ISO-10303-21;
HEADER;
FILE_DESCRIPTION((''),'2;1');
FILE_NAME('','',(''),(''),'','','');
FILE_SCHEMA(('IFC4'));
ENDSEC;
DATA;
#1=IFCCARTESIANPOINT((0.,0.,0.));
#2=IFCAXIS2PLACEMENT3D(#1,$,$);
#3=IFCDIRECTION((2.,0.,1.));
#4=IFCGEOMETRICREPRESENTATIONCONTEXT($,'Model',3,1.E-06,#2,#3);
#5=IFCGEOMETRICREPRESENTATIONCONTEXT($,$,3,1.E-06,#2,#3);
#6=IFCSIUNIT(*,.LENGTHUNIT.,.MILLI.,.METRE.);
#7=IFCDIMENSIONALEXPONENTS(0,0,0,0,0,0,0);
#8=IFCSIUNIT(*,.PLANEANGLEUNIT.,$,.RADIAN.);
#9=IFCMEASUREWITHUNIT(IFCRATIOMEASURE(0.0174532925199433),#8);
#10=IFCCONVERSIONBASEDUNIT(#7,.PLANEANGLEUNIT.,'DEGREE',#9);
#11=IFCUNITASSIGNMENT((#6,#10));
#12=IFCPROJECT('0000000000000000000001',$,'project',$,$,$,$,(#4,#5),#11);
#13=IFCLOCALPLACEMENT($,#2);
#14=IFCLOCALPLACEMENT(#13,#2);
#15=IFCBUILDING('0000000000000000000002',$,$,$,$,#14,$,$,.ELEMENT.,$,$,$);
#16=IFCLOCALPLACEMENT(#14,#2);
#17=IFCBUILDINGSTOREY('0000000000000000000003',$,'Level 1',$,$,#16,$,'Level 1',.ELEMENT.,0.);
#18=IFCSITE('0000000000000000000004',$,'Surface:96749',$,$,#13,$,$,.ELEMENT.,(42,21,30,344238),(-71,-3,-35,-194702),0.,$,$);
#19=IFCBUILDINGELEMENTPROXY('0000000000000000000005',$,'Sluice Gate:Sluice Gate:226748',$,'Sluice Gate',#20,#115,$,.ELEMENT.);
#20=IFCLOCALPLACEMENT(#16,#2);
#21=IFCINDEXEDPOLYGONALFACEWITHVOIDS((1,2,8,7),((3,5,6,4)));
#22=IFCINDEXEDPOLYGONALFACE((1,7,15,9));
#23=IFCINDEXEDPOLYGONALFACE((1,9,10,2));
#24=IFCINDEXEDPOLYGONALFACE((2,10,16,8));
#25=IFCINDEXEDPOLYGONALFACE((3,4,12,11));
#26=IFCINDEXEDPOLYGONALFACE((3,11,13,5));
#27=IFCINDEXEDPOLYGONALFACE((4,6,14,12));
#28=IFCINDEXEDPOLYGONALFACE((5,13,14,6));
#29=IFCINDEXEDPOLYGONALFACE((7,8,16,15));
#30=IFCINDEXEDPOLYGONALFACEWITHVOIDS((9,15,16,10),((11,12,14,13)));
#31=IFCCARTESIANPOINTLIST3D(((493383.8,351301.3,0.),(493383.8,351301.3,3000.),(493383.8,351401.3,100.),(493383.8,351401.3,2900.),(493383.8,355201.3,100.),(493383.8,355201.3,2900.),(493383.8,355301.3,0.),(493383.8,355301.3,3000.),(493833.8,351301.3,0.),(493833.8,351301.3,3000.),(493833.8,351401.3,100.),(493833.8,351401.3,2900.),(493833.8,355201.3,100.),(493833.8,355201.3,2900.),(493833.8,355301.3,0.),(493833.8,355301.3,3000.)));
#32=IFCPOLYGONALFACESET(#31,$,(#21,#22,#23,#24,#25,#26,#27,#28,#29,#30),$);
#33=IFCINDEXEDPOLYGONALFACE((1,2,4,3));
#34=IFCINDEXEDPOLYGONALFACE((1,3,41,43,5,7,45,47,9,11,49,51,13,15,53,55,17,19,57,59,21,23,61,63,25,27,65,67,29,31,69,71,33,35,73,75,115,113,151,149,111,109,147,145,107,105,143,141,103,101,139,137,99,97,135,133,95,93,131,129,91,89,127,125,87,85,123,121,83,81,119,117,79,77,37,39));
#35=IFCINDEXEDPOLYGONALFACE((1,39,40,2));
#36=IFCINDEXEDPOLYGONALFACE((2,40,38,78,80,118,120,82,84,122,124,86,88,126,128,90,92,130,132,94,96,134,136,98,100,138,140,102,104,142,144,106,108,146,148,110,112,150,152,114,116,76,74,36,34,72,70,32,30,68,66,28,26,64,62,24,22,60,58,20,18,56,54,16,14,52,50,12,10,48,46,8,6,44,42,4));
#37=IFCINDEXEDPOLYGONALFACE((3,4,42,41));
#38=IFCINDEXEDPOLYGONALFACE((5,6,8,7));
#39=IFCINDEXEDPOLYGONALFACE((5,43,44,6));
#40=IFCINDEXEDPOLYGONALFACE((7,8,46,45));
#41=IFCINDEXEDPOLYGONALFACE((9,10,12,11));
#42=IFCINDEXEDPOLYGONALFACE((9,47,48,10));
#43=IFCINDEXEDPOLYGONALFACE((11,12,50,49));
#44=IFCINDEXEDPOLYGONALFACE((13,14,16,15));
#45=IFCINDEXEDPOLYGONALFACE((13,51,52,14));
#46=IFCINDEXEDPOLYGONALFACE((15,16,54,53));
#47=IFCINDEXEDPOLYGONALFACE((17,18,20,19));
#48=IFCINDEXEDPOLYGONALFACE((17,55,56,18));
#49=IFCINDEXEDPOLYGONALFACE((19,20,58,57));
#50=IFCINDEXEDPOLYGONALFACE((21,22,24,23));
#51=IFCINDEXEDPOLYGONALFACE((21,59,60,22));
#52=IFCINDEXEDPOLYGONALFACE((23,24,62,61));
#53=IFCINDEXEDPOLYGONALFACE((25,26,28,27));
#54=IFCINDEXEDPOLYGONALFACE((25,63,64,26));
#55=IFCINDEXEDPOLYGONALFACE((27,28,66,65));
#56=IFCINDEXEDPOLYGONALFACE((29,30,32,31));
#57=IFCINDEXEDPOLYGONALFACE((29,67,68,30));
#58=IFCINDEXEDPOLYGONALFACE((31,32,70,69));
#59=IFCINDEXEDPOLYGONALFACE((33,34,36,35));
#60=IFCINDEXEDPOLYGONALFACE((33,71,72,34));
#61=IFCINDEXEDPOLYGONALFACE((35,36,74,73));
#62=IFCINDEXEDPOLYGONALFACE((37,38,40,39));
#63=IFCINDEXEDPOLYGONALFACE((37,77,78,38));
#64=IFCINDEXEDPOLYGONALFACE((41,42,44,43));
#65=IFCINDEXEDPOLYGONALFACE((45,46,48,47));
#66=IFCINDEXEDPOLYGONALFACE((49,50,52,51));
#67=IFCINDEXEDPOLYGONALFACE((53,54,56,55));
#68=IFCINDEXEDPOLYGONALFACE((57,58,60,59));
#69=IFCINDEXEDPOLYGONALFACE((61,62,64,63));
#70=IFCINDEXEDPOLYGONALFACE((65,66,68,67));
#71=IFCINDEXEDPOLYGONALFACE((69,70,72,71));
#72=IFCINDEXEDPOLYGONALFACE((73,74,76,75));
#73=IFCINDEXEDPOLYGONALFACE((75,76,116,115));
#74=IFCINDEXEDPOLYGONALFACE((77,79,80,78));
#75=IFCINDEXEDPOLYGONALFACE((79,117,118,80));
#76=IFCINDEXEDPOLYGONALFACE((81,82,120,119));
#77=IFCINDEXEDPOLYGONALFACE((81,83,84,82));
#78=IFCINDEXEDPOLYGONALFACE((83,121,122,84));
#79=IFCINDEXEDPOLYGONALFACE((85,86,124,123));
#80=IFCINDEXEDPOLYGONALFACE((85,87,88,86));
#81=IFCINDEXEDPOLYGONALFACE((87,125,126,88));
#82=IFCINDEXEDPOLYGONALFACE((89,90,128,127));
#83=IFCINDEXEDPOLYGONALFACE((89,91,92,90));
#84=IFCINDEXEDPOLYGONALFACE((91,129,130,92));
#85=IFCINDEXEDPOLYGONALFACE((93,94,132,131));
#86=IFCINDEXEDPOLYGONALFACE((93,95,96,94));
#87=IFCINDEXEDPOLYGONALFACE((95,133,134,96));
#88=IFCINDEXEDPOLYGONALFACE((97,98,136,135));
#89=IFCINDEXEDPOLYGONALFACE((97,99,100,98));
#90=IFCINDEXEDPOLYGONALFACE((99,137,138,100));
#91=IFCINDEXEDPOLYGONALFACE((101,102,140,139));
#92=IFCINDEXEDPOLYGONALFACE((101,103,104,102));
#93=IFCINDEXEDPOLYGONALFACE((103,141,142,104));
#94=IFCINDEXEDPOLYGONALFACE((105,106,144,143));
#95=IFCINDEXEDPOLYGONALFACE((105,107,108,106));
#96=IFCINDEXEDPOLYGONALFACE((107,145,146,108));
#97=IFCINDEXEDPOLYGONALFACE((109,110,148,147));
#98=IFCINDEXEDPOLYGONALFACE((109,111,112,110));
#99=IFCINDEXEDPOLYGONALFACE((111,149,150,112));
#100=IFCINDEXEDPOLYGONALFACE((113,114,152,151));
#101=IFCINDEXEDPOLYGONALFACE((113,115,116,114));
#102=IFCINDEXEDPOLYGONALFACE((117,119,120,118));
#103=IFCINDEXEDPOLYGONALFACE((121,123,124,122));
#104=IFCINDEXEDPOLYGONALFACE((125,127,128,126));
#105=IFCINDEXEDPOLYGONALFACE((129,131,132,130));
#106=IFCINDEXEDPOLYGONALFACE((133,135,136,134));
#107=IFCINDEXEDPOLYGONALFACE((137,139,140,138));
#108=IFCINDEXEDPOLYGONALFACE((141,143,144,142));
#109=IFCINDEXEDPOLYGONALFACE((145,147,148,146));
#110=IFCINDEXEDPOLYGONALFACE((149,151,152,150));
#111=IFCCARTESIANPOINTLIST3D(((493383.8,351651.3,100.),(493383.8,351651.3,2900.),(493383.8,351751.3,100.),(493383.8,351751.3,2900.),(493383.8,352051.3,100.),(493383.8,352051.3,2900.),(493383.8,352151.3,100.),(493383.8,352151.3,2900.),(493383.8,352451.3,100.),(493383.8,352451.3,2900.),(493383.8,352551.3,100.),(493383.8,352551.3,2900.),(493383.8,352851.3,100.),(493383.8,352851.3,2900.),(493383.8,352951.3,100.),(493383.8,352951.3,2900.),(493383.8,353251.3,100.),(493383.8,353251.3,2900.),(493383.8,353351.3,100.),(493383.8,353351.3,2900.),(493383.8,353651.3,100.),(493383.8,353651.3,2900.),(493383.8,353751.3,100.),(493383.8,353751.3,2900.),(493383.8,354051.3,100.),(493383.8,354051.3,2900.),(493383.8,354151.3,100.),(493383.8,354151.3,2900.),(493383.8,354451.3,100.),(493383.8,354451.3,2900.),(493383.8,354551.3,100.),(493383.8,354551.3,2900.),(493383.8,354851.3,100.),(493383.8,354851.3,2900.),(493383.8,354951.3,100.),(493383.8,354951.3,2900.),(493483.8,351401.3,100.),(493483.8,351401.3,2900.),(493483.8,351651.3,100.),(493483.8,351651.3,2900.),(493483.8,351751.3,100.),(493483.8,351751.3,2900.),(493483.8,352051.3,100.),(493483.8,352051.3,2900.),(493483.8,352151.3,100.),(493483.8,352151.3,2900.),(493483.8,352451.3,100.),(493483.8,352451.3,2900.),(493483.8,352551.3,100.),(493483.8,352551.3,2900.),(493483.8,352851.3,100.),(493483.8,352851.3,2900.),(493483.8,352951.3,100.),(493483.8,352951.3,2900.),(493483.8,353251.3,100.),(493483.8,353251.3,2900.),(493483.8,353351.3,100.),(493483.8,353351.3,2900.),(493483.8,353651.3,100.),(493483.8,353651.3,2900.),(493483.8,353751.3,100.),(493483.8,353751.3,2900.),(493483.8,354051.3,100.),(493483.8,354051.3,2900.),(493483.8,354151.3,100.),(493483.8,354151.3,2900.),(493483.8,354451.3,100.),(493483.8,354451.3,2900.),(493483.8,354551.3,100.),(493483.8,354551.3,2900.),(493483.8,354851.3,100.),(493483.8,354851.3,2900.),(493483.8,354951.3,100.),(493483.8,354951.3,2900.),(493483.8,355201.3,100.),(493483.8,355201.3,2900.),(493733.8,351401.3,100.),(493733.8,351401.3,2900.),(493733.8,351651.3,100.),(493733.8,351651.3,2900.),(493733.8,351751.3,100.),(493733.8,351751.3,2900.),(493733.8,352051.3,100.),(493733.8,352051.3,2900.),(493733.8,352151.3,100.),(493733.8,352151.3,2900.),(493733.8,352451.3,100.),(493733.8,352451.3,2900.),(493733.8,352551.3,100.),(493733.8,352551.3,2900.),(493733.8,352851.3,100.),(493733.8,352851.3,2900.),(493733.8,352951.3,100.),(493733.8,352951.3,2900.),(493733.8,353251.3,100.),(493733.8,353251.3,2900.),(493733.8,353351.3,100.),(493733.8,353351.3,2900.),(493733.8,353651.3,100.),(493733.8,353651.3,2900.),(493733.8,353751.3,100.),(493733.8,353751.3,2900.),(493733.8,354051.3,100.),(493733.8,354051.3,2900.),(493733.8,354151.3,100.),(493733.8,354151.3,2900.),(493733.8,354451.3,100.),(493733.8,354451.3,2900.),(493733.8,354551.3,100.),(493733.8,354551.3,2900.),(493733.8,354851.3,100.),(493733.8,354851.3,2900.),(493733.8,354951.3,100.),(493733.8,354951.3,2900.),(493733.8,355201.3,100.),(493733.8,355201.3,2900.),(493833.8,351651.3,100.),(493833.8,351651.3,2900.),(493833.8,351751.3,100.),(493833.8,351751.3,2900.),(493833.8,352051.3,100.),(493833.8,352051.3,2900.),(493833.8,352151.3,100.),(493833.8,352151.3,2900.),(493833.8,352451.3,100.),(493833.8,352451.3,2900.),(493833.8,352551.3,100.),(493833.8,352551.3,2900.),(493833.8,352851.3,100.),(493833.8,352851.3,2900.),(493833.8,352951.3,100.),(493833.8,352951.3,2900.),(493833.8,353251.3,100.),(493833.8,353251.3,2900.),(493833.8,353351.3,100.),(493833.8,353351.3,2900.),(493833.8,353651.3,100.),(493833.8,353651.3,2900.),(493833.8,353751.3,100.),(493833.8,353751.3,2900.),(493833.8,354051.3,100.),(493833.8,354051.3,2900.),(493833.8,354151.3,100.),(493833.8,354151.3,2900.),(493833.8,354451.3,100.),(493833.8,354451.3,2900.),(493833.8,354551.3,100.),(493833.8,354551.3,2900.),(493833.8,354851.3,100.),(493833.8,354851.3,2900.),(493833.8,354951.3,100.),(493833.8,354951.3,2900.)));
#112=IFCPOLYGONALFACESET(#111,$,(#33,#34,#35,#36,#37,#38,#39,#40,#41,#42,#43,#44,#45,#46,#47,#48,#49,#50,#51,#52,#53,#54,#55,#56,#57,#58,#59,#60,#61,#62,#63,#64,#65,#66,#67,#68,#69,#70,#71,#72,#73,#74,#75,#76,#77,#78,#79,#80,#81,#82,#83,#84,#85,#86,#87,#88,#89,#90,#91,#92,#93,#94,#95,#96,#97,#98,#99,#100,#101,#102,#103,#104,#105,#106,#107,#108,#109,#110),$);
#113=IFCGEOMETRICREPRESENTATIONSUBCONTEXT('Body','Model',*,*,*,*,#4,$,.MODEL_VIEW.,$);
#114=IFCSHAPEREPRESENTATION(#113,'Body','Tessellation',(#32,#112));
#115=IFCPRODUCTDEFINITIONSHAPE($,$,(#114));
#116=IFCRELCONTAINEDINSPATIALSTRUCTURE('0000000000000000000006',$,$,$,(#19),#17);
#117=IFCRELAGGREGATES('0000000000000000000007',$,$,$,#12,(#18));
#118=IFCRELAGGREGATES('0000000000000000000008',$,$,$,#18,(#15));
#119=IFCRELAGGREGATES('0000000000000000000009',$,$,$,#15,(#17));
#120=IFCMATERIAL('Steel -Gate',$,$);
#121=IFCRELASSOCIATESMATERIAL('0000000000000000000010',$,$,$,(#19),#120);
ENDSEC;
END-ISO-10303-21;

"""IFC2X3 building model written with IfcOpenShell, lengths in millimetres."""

from ifc_helpers import new_model, entity, si_unit, converted_unit, direction, frame, origin, place, context, subcontext, project, spatial, polyline, outline, extrude, source, transform, mapped, material, element, save


model = new_model("IFC2X3")

# Units and contexts
model_context = context("Model", 3, precision=1e-06, world=origin(), true_north=direction((2.0, 0.0, 1.0)))
context_of_model = context(None, 3, precision=1e-06, world=origin(), true_north=direction((2.0, 0.0, 1.0)))
body_context = subcontext(model_context, "Body", "Model", "MODEL_VIEW")
ifc_project = project(units=[si_unit("LENGTHUNIT", "METRE", prefix="MILLI"), converted_unit("PLANEANGLEUNIT", "DEGREE", entity("IfcRatioMeasure", 0.0174532925199433), si_unit("PLANEANGLEUNIT", "RADIAN"), dimensions=[0, 0, 0, 0, 0, 0, 0])], contexts=[model_context, context_of_model])

# Site, building, storey
site_placement = place(None, origin())
site = spatial("IfcSite", under=ifc_project, at=site_placement, Name="Surface:96749", CompositionType="ELEMENT", RefLatitude=(42, 21, 30, 344238), RefLongitude=(-71, -3, -35, -194702), RefElevation=0.0)
building_placement = place(site_placement, origin())
building = spatial("IfcBuilding", under=site, at=building_placement, CompositionType="ELEMENT")
storey_placement = place(building_placement, origin())
storey = spatial("IfcBuildingStorey", under=building, at=storey_placement, Name="Level 1", LongName="Level 1", CompositionType="ELEMENT", Elevation=0.0)

# Building element proxy
ifc_material = material(Name="Steel -Gate")
shared_shape_1 = source(origin(), body_context, "Body", "SweptSolid", [
    extrude(outline(polyline([(-2000.0, -1500.0), (2000.0, -1500.0), (2000.0, 1500.0), (-2000.0, 1500.0), (-2000.0, -1500.0)]), holes=[polyline([(-1900.0, 1400.0), (1900.0, 1400.0), (1900.0, -1400.0), (-1900.0, -1400.0), (-1900.0, 1400.0)])]), frame((0.0, -225.0, 1500.0), z_axis=(0.0, 1.0, 0.0), x_axis=(-1.0, 0.0, 0.0)), (0.0, 0.0, 1.0), 450.0),
    extrude(outline(polyline([(125.0, -1650.0), (225.0, -1650.0), (225.0, -1550.0), (125.0, -1550.0), (125.0, -1250.0), (225.0, -1250.0), (225.0, -1150.0), (125.0, -1150.0), (125.0, -850.0), (225.0, -850.0), (225.0, -750.0), (125.0, -750.0), (125.0, -450.0), (225.0, -450.0), (225.0, -350.0), (125.0, -350.0), (125.0, -50.0), (225.0, -50.0), (225.0, 50.0), (125.0, 50.0), (125.0, 350.0), (225.0, 350.0), (225.0, 450.0), (125.0, 450.0), (125.0, 750.0), (225.0, 750.0), (225.0, 850.0), (125.0, 850.0), (125.0, 1150.0), (225.0, 1150.0), (225.0, 1250.0), (125.0, 1250.0), (125.0, 1550.0), (225.0, 1550.0), (225.0, 1650.0), (125.0, 1650.0), (125.0, 1900.0), (-125.0, 1900.0), (-125.0, 1650.0), (-225.0, 1650.0), (-225.0, 1550.0), (-125.0, 1550.0), (-125.0, 1250.0), (-225.0, 1250.0), (-225.0, 1150.0), (-125.0, 1150.0), (-125.0, 850.0), (-225.0, 850.0), (-225.0, 750.0), (-125.0, 750.0), (-125.0, 450.0), (-225.0, 450.0), (-225.0, 350.0), (-125.0, 350.0), (-125.0, 50.0), (-225.0, 50.0), (-225.0, -50.0), (-125.0, -50.0), (-125.0, -350.0), (-225.0, -350.0), (-225.0, -450.0), (-125.0, -450.0), (-125.0, -750.0), (-225.0, -750.0), (-225.0, -850.0), (-125.0, -850.0), (-125.0, -1150.0), (-225.0, -1150.0), (-225.0, -1250.0), (-125.0, -1250.0), (-125.0, -1550.0), (-225.0, -1550.0), (-225.0, -1650.0), (-125.0, -1650.0), (-125.0, -1900.0), (125.0, -1900.0), (125.0, -1650.0)])), frame((0.0, 0.0, 100.0), z_axis=(0.0, 0.0, 1.0), x_axis=(0.0, -1.0, 0.0)), (0.0, 0.0, 1.0), 2800.0),
])
for number, where, z_axis, x_axis, name in (
    (1, (493608.8, 353301.3, 0.0), (0.0, 0.0, 1.0), (0.0, 1.0, 0.0), "Sluice Gate:Sluice Gate:226748"),
):
    element("IfcBuildingElementProxy", number, at=place(storey_placement, frame(where, z_axis=z_axis, x_axis=x_axis)), inside=storey, material=ifc_material, Name=name, ObjectType="Sluice Gate", CompositionType="ELEMENT", context=body_context, shape_type="MappedRepresentation", body=[
        mapped(shared_shape_1, transform((0.0, 0.0, 0.0), scale=1.0)),
    ])

save(model, "model.ifc")
